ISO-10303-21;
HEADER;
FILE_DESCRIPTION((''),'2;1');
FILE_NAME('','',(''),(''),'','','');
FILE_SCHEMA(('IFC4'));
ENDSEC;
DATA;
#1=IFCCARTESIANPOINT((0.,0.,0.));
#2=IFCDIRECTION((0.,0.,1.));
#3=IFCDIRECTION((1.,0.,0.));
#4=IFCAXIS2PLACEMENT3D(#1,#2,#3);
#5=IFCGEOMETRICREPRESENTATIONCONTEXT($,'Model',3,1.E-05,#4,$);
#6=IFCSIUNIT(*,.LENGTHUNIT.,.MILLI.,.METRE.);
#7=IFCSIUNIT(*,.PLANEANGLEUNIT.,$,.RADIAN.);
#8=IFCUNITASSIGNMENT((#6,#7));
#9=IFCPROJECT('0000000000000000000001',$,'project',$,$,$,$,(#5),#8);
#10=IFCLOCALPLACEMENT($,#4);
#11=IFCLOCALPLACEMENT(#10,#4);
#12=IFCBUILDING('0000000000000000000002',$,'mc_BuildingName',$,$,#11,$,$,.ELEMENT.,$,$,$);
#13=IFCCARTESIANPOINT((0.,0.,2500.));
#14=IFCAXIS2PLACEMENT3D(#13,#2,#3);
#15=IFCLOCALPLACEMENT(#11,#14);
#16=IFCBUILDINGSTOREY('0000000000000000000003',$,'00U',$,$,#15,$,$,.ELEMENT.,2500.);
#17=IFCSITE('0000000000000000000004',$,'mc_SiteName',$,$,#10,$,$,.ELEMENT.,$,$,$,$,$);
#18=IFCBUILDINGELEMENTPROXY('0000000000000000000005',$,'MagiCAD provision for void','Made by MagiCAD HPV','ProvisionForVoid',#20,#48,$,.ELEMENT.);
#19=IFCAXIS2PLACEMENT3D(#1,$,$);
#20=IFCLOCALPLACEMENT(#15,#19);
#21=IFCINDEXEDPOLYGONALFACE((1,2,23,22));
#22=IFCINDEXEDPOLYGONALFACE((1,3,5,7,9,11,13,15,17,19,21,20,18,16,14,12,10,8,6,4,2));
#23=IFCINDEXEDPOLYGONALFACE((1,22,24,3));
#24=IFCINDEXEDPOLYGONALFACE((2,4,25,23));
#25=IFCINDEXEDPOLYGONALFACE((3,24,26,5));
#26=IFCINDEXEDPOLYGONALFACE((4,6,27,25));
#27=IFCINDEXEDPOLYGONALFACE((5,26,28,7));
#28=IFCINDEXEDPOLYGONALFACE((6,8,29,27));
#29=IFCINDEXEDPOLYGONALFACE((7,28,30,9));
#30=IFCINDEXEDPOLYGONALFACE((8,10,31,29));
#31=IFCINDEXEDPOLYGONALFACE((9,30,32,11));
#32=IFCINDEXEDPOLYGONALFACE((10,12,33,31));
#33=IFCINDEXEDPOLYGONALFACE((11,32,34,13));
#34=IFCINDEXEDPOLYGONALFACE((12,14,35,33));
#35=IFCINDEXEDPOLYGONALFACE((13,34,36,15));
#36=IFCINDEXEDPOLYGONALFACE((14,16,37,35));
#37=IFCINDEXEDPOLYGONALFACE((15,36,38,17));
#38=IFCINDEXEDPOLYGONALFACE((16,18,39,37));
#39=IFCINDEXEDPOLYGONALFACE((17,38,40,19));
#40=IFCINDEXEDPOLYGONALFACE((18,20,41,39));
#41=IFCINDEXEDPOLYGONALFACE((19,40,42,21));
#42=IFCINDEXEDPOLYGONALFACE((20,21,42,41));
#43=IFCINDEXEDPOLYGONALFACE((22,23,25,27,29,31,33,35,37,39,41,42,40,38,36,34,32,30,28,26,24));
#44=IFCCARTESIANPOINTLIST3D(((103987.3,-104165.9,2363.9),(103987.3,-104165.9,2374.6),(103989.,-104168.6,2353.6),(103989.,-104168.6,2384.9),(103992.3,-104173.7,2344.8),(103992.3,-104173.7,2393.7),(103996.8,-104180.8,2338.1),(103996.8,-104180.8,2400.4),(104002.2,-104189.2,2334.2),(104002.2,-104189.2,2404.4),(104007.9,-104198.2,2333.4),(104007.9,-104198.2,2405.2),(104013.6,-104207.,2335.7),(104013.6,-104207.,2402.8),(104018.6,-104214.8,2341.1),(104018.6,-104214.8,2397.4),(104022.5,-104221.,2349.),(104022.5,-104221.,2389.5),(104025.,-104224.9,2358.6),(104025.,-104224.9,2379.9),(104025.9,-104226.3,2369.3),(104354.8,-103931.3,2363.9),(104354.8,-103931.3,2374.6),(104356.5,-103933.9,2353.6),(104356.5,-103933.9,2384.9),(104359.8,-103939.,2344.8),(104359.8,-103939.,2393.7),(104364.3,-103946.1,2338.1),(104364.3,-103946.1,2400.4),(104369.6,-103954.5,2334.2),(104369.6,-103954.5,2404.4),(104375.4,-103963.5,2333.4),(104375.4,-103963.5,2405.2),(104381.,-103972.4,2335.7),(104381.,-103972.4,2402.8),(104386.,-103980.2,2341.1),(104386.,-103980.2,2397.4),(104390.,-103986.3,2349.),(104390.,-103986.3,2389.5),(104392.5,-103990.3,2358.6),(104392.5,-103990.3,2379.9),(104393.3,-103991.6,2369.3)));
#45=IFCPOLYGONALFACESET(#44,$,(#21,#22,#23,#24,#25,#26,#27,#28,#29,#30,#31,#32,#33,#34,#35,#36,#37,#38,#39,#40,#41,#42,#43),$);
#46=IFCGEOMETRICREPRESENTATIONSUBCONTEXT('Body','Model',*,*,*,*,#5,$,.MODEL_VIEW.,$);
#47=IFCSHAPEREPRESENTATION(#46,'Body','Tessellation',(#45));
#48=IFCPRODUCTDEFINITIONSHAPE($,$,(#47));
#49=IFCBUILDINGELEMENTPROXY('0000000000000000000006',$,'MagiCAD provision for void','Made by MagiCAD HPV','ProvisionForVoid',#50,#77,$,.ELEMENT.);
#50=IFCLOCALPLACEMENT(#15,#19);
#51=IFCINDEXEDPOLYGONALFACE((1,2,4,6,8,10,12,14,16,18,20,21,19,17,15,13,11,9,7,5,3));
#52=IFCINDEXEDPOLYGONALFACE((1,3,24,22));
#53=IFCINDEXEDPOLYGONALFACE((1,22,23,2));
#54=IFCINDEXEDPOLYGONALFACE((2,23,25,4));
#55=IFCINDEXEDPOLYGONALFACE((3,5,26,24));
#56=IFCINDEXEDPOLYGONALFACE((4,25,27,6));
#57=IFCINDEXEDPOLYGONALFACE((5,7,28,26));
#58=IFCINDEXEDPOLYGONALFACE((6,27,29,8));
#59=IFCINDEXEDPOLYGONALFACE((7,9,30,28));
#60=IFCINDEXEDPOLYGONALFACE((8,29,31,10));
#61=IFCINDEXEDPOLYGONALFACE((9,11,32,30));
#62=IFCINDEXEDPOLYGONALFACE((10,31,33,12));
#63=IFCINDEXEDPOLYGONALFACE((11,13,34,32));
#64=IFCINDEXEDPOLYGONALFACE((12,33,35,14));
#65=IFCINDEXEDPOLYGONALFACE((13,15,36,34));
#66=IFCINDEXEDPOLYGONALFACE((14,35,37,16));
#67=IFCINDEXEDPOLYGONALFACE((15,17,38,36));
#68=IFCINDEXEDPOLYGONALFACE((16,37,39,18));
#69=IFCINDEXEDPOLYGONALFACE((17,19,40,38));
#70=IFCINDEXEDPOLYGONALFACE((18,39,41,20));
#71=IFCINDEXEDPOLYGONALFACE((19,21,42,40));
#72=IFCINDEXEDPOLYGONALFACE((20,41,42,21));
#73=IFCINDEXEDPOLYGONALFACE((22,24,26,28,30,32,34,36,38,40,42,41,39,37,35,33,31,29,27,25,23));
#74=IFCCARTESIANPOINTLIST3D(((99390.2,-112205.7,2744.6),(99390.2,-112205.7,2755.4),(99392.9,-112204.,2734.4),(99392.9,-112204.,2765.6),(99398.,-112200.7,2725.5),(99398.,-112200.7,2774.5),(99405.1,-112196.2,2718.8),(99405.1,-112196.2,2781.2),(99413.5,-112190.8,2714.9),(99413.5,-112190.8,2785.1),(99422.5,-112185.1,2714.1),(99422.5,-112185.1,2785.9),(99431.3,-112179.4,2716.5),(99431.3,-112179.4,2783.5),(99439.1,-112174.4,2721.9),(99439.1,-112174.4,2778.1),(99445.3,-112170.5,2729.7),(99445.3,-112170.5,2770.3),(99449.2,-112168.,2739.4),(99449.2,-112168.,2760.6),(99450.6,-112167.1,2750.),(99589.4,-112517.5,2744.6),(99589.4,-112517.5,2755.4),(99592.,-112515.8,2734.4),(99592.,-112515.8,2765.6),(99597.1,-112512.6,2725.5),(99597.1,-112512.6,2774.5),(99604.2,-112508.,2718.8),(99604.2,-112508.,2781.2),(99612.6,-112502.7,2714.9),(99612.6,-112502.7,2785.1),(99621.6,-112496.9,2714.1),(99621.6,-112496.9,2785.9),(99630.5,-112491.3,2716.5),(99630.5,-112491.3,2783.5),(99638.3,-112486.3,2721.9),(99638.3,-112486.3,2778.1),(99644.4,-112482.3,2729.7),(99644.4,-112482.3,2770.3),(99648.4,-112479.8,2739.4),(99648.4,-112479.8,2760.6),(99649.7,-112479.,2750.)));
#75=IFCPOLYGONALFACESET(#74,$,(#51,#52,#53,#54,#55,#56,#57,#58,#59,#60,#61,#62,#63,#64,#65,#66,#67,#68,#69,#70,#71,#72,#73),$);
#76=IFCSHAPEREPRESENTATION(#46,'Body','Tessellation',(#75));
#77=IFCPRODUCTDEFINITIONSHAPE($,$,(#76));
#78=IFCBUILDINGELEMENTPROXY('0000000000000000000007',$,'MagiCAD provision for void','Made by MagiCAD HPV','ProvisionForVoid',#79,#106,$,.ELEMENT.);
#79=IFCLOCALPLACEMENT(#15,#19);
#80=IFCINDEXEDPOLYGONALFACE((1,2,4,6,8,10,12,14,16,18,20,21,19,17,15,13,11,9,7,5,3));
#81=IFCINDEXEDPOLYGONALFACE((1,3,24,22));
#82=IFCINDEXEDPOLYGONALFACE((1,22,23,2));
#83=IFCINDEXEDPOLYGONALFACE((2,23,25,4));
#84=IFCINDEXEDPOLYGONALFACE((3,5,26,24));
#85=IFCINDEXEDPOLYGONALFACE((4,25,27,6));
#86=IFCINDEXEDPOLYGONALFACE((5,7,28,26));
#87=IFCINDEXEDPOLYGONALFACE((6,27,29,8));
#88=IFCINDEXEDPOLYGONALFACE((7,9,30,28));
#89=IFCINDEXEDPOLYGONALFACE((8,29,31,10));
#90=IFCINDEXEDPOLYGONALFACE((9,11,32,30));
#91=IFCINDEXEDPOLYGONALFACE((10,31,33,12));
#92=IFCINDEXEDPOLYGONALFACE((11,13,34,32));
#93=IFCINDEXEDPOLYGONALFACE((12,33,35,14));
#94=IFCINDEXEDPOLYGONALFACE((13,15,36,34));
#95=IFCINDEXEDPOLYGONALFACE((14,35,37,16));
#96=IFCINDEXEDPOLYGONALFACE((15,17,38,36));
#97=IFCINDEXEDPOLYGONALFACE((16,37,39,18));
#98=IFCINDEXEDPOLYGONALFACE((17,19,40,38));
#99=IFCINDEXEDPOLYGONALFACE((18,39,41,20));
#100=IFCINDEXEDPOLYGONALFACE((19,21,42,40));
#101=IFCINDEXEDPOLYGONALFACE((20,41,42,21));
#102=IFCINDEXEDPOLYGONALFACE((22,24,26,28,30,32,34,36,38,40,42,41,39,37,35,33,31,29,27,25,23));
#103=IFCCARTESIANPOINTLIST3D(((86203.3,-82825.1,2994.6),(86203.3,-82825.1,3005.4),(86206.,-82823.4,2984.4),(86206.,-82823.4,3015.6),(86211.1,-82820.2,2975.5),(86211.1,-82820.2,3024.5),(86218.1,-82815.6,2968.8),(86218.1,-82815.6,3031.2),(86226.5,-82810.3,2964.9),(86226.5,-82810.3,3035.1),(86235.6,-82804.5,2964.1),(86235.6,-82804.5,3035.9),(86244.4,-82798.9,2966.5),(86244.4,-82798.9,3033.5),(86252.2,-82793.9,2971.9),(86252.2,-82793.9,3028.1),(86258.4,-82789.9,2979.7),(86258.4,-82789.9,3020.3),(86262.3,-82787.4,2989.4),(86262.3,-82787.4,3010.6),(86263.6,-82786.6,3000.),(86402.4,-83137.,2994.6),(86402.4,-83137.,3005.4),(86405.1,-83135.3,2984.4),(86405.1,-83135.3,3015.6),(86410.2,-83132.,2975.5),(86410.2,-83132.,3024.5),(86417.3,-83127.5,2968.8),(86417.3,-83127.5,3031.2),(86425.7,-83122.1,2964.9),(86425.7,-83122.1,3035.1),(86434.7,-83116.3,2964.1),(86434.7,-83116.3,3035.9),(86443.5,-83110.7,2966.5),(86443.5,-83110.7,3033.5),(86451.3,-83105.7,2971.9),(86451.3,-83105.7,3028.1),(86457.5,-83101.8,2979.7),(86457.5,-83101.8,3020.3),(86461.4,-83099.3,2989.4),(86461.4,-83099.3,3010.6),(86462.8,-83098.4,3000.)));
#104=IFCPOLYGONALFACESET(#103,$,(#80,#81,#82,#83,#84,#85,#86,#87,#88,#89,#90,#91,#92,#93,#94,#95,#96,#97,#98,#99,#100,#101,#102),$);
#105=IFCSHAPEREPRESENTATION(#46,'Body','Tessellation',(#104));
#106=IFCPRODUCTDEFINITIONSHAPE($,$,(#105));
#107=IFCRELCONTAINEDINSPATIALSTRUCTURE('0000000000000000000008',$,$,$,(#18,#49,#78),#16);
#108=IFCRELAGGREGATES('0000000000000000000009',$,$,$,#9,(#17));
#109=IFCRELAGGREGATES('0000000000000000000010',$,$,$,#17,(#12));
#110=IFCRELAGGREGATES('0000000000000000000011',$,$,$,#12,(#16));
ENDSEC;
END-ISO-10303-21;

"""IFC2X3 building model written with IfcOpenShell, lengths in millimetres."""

from ifc_helpers import new_model, si_unit, frame, origin_with_axes, origin_2d_with_axis, place, context, subcontext, project, spatial, circle, extrude, source, transform, mapped, element, save


model = new_model("IFC2X3")

# Units and contexts
model_context = context("Model", 3, precision=1e-05, world=origin_with_axes())
body_context = subcontext(model_context, "Body", "Model", "MODEL_VIEW")
ifc_project = project(units=[si_unit("LENGTHUNIT", "METRE", prefix="MILLI"), si_unit("PLANEANGLEUNIT", "RADIAN")], contexts=[model_context])

# Site, building, storey
site_placement = place(None, origin_with_axes())
site = spatial("IfcSite", under=ifc_project, at=site_placement, Name="mc_SiteName", CompositionType="ELEMENT")
building_placement = place(site_placement, origin_with_axes())
building = spatial("IfcBuilding", under=site, at=building_placement, Name="mc_BuildingName", CompositionType="ELEMENT")
storey_placement = place(building_placement, frame((0.0, 0.0, 2500.0), z_axis=(0.0, 0.0, 1.0), x_axis=(1.0, 0.0, 0.0)))
storey = spatial("IfcBuildingStorey", under=building, at=storey_placement, Name="00U", CompositionType="ELEMENT", Elevation=2500.0)

# Building element proxies
shared_shape_1 = source(origin_with_axes(), body_context, "Body", "SweptSolid", [
    extrude(circle(Radius=36.0, at=origin_2d_with_axis()), frame((0.0, 0.0, 0.0), z_axis=(1.0, 0.0, 0.0), x_axis=(0.0, 1.0, 0.0)), (0.0, 0.0, 1.0), 436.0),
])
proxy_1_placement = place(storey_placement, frame((104374.0, -103961.3, 2369.3), z_axis=(0.0, 0.0, 1.0), x_axis=(-0.842809, -0.538213, 0.0)))
element("IfcBuildingElementProxy", 1, at=proxy_1_placement, inside=storey, Name="MagiCAD provision for void", Description="Made by MagiCAD HPV", ObjectType="ProvisionForVoid", CompositionType="ELEMENT", context=body_context, shape_type="MappedRepresentation", body=[
    mapped(shared_shape_1, transform((0.0, 0.0, 0.0), scale=1.0)),
])
shared_shape_2 = source(origin_with_axes(), body_context, "Body", "SweptSolid", [
    extrude(circle(Radius=36.0, at=origin_2d_with_axis()), frame((0.0, 0.0, 0.0), z_axis=(1.0, 0.0, 0.0), x_axis=(0.0, 1.0, 0.0)), (0.0, 0.0, 1.0), 370.0),
])
proxy_2_placement = place(storey_placement, frame((99420.2, -112186.5, 2750.0), z_axis=(0.0, 0.0, 1.0), x_axis=(0.538213, -0.842809, 0.0)))
element("IfcBuildingElementProxy", 2, at=proxy_2_placement, inside=storey, Name="MagiCAD provision for void", Description="Made by MagiCAD HPV", ObjectType="ProvisionForVoid", CompositionType="ELEMENT", context=body_context, shape_type="MappedRepresentation", body=[
    mapped(shared_shape_2, transform((0.0, 0.0, 0.0), scale=1.0)),
])
shared_shape_3 = source(origin_with_axes(), body_context, "Body", "SweptSolid", [
    extrude(circle(Radius=36.0, at=origin_2d_with_axis()), frame((0.0, 0.0, 0.0), z_axis=(1.0, 0.0, 0.0), x_axis=(0.0, 1.0, 0.0)), (0.0, 0.0, 1.0), 370.0),
])
proxy_3_placement = place(storey_placement, frame((86233.3, -82806.0, 3000.0), z_axis=(0.0, 0.0, 1.0), x_axis=(0.538213, -0.842809, 0.0)))
element("IfcBuildingElementProxy", 3, at=proxy_3_placement, inside=storey, Name="MagiCAD provision for void", Description="Made by MagiCAD HPV", ObjectType="ProvisionForVoid", CompositionType="ELEMENT", context=body_context, shape_type="MappedRepresentation", body=[
    mapped(shared_shape_3, transform((0.0, 0.0, 0.0), scale=1.0)),
])

save(model, "model.ifc")
